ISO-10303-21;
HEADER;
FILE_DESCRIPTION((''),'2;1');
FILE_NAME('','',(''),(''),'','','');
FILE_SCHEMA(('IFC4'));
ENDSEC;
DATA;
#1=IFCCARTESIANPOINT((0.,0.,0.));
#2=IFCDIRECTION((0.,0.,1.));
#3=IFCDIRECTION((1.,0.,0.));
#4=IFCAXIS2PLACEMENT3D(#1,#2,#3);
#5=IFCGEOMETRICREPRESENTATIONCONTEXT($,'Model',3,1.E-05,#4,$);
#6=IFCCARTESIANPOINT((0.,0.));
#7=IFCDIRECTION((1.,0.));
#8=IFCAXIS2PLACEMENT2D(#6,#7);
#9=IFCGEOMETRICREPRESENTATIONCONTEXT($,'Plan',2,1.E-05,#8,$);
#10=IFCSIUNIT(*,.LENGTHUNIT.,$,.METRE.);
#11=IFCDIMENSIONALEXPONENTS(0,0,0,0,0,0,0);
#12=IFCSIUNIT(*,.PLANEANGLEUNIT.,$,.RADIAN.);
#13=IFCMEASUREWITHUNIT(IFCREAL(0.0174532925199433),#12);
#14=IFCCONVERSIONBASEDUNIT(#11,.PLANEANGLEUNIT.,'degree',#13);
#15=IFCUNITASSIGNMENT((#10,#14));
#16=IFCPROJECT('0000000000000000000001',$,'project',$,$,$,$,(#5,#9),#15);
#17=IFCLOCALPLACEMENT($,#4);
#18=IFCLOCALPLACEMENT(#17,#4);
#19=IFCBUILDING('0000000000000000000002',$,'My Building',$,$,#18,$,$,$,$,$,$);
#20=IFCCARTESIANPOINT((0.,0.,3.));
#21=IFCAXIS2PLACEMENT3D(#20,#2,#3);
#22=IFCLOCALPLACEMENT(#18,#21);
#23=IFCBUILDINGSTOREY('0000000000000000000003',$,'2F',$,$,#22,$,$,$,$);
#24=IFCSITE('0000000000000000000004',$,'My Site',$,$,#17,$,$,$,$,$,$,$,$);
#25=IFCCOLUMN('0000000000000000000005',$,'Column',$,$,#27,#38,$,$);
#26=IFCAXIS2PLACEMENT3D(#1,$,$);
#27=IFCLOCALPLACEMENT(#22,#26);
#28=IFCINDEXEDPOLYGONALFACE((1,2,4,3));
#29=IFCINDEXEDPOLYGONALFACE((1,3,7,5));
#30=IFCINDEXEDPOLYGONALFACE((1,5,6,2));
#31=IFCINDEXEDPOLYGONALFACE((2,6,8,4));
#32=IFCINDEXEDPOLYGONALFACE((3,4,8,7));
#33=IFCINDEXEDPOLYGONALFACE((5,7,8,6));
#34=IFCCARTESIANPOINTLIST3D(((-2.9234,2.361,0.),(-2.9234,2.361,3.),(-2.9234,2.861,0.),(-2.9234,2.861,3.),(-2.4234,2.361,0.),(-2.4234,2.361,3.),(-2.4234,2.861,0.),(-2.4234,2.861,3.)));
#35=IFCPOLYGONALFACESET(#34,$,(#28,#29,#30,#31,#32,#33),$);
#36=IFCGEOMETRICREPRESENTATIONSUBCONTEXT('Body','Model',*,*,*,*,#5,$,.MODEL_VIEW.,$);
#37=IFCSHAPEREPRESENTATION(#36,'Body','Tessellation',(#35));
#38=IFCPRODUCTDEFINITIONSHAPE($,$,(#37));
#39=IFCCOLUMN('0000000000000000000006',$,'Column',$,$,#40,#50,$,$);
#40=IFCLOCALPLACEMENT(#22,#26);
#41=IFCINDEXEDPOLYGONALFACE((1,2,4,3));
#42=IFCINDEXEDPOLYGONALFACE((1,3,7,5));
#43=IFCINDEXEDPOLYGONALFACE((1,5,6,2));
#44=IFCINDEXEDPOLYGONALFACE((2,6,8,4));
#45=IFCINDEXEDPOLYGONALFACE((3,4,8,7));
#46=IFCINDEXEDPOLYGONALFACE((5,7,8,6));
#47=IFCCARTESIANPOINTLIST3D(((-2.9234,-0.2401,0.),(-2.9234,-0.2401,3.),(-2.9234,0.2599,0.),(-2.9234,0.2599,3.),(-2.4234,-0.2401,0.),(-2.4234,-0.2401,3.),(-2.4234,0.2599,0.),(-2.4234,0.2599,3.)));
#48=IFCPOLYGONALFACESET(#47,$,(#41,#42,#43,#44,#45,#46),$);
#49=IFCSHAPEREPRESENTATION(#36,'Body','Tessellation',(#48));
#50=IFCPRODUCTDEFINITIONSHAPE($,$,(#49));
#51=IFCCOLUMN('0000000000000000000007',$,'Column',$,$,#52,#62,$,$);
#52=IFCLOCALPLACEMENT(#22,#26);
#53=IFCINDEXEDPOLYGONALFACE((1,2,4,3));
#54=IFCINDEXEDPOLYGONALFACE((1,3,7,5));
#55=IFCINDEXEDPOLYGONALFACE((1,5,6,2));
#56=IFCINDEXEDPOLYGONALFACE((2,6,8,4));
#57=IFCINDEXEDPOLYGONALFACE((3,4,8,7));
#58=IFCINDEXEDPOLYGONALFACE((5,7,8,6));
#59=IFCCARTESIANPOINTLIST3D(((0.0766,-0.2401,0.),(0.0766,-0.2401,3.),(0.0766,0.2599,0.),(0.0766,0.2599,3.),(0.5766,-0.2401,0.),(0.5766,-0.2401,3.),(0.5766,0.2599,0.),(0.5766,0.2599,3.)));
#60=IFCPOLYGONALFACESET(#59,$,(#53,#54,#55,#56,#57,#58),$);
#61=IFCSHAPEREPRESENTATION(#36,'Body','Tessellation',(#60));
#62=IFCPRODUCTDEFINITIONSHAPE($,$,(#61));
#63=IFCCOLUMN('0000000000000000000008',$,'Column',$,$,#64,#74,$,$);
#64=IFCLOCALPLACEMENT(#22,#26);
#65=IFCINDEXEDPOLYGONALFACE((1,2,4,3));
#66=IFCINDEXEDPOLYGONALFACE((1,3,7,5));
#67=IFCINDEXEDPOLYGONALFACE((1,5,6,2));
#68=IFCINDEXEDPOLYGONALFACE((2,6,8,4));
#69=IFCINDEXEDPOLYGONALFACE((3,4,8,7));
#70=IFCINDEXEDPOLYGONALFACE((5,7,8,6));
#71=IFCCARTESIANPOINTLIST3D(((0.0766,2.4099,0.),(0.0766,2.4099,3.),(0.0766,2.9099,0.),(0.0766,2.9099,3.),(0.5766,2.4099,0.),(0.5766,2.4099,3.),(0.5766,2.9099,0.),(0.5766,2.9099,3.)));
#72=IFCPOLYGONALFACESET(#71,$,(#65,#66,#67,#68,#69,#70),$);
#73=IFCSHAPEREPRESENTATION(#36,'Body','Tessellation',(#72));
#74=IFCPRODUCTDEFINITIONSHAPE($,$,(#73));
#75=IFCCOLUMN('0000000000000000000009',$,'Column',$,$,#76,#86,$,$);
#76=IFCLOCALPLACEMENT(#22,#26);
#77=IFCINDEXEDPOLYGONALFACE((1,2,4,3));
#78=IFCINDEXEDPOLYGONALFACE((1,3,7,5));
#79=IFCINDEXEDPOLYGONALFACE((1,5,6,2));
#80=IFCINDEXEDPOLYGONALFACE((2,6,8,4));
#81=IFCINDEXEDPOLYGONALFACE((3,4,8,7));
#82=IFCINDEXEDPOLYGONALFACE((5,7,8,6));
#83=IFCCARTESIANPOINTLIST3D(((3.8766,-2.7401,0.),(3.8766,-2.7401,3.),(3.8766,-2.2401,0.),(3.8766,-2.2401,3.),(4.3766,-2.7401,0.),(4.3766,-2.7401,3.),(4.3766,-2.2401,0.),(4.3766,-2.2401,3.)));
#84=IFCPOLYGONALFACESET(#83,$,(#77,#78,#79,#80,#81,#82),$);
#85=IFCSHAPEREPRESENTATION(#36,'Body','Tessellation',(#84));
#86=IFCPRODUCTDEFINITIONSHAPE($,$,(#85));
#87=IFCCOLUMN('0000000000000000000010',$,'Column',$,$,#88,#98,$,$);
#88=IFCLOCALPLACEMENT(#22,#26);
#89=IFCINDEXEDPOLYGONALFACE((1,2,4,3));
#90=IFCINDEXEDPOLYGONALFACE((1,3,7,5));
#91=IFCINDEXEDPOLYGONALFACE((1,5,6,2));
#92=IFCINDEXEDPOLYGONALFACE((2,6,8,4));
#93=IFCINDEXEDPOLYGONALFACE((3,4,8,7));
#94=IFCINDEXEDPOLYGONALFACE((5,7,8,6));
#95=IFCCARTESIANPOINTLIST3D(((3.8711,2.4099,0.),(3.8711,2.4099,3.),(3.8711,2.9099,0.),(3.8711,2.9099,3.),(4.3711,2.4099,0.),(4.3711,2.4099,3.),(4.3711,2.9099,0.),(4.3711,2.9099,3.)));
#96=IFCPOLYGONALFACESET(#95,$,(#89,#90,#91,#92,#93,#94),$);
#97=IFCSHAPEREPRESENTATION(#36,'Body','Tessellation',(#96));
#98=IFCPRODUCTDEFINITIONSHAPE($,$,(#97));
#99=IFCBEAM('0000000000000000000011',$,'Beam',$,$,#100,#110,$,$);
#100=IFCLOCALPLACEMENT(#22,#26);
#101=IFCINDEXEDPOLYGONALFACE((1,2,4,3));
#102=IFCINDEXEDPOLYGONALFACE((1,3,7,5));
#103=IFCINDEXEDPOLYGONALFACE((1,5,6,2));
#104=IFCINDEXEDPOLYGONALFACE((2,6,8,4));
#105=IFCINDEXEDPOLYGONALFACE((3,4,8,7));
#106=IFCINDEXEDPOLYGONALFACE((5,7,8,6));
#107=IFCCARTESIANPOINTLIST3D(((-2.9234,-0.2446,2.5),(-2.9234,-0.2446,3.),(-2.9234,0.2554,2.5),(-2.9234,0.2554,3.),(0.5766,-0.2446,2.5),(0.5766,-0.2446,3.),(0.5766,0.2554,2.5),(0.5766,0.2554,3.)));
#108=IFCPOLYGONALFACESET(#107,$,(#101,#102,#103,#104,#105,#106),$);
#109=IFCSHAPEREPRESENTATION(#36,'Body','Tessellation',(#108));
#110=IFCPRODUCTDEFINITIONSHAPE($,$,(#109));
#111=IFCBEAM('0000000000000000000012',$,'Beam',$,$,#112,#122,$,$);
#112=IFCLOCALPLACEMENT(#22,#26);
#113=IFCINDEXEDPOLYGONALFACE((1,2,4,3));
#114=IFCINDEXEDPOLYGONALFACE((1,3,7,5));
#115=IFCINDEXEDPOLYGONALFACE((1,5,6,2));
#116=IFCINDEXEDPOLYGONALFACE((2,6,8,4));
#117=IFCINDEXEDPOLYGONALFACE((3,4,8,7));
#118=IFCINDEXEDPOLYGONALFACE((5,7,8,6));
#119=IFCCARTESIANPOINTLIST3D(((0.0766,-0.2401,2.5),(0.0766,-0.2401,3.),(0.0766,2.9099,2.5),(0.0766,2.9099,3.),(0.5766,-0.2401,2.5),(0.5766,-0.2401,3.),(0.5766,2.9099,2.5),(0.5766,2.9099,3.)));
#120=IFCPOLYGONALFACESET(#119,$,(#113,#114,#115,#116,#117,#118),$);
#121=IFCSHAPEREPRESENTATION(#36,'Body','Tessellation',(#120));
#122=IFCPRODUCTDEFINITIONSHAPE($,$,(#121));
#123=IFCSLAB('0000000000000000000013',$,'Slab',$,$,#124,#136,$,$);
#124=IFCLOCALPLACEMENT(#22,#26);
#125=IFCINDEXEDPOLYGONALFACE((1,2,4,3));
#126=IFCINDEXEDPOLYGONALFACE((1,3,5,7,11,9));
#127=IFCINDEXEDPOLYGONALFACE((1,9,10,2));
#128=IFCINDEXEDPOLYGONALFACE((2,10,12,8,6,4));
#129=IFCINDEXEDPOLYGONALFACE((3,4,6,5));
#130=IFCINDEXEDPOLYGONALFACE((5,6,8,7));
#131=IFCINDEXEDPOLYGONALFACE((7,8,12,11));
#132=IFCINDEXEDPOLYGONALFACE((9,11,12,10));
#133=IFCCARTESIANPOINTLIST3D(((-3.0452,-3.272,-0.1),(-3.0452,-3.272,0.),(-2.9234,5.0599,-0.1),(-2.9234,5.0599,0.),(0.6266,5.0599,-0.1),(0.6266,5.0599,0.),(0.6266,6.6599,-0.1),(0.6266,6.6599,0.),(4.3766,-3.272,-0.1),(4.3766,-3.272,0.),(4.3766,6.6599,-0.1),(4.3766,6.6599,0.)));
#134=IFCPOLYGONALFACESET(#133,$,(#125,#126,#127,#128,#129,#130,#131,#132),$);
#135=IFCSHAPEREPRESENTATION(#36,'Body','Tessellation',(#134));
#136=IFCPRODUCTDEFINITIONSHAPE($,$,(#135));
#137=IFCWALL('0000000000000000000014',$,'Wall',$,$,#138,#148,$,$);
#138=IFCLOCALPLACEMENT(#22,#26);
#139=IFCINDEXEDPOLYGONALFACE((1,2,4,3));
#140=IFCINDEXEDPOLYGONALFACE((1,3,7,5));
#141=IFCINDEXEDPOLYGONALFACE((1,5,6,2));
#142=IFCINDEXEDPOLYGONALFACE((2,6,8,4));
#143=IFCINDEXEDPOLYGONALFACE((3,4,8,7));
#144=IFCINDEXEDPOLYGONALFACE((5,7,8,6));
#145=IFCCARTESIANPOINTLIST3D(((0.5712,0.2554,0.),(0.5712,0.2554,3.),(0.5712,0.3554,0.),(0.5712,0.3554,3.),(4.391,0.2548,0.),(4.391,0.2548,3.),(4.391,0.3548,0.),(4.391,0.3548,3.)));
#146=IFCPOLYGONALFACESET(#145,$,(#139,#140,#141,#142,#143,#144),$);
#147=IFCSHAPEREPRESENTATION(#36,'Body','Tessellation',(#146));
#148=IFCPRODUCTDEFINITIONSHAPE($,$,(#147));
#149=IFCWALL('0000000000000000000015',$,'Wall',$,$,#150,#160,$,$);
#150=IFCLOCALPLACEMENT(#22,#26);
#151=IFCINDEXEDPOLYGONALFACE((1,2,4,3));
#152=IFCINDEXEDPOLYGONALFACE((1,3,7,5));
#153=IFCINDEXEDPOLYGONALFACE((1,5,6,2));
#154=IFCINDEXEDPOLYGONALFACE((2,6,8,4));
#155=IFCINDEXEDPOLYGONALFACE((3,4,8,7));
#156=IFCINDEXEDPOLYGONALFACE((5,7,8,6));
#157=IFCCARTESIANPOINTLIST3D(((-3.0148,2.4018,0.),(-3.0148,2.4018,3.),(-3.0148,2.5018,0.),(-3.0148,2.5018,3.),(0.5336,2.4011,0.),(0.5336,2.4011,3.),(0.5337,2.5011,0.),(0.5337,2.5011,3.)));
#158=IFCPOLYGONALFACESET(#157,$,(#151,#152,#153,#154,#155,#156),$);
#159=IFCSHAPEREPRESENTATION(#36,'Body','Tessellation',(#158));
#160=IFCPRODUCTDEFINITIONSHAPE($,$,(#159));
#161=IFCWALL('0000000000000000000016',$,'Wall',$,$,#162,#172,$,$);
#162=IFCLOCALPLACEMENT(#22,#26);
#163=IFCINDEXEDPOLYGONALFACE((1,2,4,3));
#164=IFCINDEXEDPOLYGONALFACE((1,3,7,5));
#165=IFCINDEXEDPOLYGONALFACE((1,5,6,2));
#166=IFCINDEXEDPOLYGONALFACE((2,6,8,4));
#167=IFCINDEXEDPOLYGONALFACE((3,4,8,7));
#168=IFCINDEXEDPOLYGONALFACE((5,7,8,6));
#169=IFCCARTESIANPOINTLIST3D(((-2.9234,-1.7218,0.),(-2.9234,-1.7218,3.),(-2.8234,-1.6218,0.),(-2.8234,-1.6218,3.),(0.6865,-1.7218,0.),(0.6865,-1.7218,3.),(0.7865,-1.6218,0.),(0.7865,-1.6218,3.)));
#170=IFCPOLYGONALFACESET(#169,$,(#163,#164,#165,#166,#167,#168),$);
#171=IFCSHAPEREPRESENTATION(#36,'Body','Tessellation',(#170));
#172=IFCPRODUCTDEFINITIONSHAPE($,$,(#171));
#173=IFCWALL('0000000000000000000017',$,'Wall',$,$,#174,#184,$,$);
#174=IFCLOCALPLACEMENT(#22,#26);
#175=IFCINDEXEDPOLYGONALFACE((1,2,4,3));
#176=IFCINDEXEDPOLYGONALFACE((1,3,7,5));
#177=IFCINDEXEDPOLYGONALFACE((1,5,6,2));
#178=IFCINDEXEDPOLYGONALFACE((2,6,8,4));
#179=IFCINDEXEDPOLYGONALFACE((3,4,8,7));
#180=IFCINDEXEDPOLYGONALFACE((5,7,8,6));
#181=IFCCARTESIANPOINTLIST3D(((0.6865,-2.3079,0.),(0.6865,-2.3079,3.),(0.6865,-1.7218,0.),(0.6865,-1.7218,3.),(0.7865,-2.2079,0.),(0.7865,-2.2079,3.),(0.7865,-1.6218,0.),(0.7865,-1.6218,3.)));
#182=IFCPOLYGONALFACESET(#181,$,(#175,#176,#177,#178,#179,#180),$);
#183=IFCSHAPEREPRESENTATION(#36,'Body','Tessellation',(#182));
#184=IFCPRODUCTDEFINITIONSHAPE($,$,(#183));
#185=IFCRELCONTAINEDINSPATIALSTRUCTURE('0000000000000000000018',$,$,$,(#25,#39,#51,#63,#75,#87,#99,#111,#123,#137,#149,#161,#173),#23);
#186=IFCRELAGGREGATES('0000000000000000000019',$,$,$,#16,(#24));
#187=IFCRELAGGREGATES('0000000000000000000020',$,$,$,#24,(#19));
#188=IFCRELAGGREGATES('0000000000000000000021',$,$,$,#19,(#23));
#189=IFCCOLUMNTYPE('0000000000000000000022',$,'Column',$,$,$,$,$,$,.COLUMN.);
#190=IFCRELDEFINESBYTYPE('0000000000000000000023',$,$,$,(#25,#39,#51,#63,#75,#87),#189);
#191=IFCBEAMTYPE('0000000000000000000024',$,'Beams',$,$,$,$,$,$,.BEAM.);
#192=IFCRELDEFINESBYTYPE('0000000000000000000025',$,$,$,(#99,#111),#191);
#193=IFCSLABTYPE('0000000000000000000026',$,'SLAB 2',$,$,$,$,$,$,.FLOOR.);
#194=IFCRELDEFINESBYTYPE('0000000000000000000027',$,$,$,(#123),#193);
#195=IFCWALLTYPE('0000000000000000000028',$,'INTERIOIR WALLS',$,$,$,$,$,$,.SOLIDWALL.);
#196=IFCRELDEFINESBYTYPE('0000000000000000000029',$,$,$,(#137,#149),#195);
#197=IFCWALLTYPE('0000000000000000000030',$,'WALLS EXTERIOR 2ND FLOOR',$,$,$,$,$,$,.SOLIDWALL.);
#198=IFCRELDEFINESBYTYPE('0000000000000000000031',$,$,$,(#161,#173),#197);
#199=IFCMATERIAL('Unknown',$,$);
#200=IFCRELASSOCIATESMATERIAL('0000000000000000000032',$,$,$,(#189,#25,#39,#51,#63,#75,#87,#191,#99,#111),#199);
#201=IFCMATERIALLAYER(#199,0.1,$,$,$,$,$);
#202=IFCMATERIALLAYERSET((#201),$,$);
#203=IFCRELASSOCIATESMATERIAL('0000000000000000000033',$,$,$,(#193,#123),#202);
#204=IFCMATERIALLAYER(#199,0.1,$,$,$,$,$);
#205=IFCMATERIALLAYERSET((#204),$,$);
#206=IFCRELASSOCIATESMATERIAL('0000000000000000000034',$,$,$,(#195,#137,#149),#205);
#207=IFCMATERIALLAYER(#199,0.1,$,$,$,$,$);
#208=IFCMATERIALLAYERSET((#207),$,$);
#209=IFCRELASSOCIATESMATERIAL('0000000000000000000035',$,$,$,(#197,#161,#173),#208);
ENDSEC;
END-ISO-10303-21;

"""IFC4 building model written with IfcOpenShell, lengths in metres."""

from ifc_helpers import new_model, entity, si_unit, converted_unit, frame, origin_with_axes, origin_2d_with_axis, place, context, subcontext, project, spatial, line, indexed_curve, rectangle, outline, extrude, material, layer, layer_set, layer_usage, material_profile, profile_set, profile_usage, type_object, element, save


model = new_model("IFC4")

# Units and contexts
model_context = context("Model", 3, precision=1e-05, world=origin_with_axes())
plan_context = context("Plan", 2, precision=1e-05, world=origin_2d_with_axis())
body_context_1 = subcontext(model_context, "Body", "Model", "MODEL_VIEW")
ifc_project = project(units=[si_unit("LENGTHUNIT", "METRE"), converted_unit("PLANEANGLEUNIT", "degree", entity("IfcReal", 0.0174532925199433), si_unit("PLANEANGLEUNIT", "RADIAN"), dimensions=[0, 0, 0, 0, 0, 0, 0])], contexts=[model_context, plan_context])

# Site, building, storey
site_placement = place(None, origin_with_axes())
site = spatial("IfcSite", under=ifc_project, at=site_placement, Name="My Site")
building_placement = place(site_placement, origin_with_axes())
building = spatial("IfcBuilding", under=site, at=building_placement, Name="My Building")
storey_placement = place(building_placement, frame((0.0, 0.0, 3.0), z_axis=(0.0, 0.0, 1.0), x_axis=(1.0, 0.0, 0.0)))
storey = spatial("IfcBuildingStorey", under=building, at=storey_placement, Name="2F")

# Columns
ifc_material = material(Name="Unknown")
ifc_material_profile_1 = material_profile(ifc_material, rectangle(XDim=0.5, YDim=0.5))
ifc_profile_set_1 = profile_set([ifc_material_profile_1])
ifc_profile_usage_1 = profile_usage(ifc_profile_set_1, cardinal=5)
column_type = type_object("IfcColumnType", Name="Column", PredefinedType="COLUMN", material=ifc_profile_set_1)
column_1_placement = place(storey_placement, frame((-2.6734, 2.611, 0.0), z_axis=(0.0, 0.0, 1.0), x_axis=(1.0, 0.0, 0.0)))
element("IfcColumn", 1, at=column_1_placement, inside=storey, type_object=column_type, material=ifc_profile_usage_1, Name="Column", context=body_context_1, shape_type="SweptSolid", body=[
    extrude(rectangle(XDim=0.5, YDim=0.5), origin_with_axes(), (0.0, 0.0, 1.0), 3.0),
])
ifc_profile_usage_2 = profile_usage(ifc_profile_set_1, cardinal=5)
column_2_placement = place(storey_placement, frame((-2.6734, 0.0099, 0.0), z_axis=(0.0, 0.0, 1.0), x_axis=(1.0, 0.0, 0.0)))
element("IfcColumn", 2, at=column_2_placement, inside=storey, type_object=column_type, material=ifc_profile_usage_2, Name="Column", context=body_context_1, shape_type="SweptSolid", body=[
    extrude(rectangle(XDim=0.5, YDim=0.5), origin_with_axes(), (0.0, 0.0, 1.0), 3.0),
])
ifc_profile_usage_3 = profile_usage(ifc_profile_set_1, cardinal=5)
column_3_placement = place(storey_placement, frame((0.3266, 0.0099, 0.0), z_axis=(0.0, 0.0, 1.0), x_axis=(1.0, 0.0, 0.0)))
element("IfcColumn", 3, at=column_3_placement, inside=storey, type_object=column_type, material=ifc_profile_usage_3, Name="Column", context=body_context_1, shape_type="SweptSolid", body=[
    extrude(rectangle(XDim=0.5, YDim=0.5), origin_with_axes(), (0.0, 0.0, 1.0), 3.0),
])
ifc_profile_usage_4 = profile_usage(ifc_profile_set_1, cardinal=5)
column_4_placement = place(storey_placement, frame((0.3266, 2.6599, 0.0), z_axis=(0.0, 0.0, 1.0), x_axis=(1.0, 0.0, 0.0)))
element("IfcColumn", 4, at=column_4_placement, inside=storey, type_object=column_type, material=ifc_profile_usage_4, Name="Column", context=body_context_1, shape_type="SweptSolid", body=[
    extrude(rectangle(XDim=0.5, YDim=0.5), origin_with_axes(), (0.0, 0.0, 1.0), 3.0),
])
ifc_profile_usage_5 = profile_usage(ifc_profile_set_1, cardinal=5)
column_5_placement = place(storey_placement, frame((4.1266, -2.4901, 0.0), z_axis=(0.0, 0.0, 1.0), x_axis=(1.0, 0.0, 0.0)))
element("IfcColumn", 5, at=column_5_placement, inside=storey, type_object=column_type, material=ifc_profile_usage_5, Name="Column", context=body_context_1, shape_type="SweptSolid", body=[
    extrude(rectangle(XDim=0.5, YDim=0.5), origin_with_axes(), (0.0, 0.0, 1.0), 3.0),
])
ifc_profile_usage_6 = profile_usage(ifc_profile_set_1, cardinal=5)
column_6_placement = place(storey_placement, frame((4.1211, 2.6599, 0.0), z_axis=(0.0, 0.0, 1.0), x_axis=(1.0, 0.0, 0.0)))
element("IfcColumn", 6, at=column_6_placement, inside=storey, type_object=column_type, material=ifc_profile_usage_6, Name="Column", context=body_context_1, shape_type="SweptSolid", body=[
    extrude(rectangle(XDim=0.5, YDim=0.5), origin_with_axes(), (0.0, 0.0, 1.0), 3.0),
])

# Beams
ifc_material_profile_2 = material_profile(ifc_material, rectangle(XDim=0.5, YDim=0.5))
ifc_profile_set_2 = profile_set([ifc_material_profile_2])
ifc_profile_usage_7 = profile_usage(ifc_profile_set_2, cardinal=7)
beam_type = type_object("IfcBeamType", Name="Beams", PredefinedType="BEAM", material=ifc_profile_set_2)
beam_1_placement = place(storey_placement, frame((-2.9234, 0.2554, 3.0), z_axis=(1.0, 0.0, 0.0), x_axis=(0.0, 1.0, 0.0)))
element("IfcBeam", 7, at=beam_1_placement, inside=storey, type_object=beam_type, material=ifc_profile_usage_7, Name="Beam", context=body_context_1, shape_type="SweptSolid", body=[
    extrude(rectangle(XDim=0.5, YDim=0.5), frame((-0.25, -0.25, 0.0), z_axis=(0.0, 0.0, 1.0), x_axis=(1.0, 0.0, 0.0)), (0.0, 0.0, 1.0), 3.5),
])
ifc_profile_usage_8 = profile_usage(ifc_profile_set_2, cardinal=7)
beam_2_placement = place(storey_placement, frame((0.0766, -0.2401, 3.0), z_axis=(0.0, 1.0, 0.0), x_axis=(-1.0, 0.0, 0.0)))
element("IfcBeam", 8, at=beam_2_placement, inside=storey, type_object=beam_type, material=ifc_profile_usage_8, Name="Beam", context=body_context_1, shape_type="SweptSolid", body=[
    extrude(rectangle(XDim=0.5, YDim=0.5), frame((-0.25, -0.25, 0.0), z_axis=(0.0, 0.0, 1.0), x_axis=(1.0, 0.0, 0.0)), (0.0, 0.0, 1.0), 3.15),
])

# Slab
ifc_layer_1 = layer(ifc_material, 0.1)
ifc_layer_set_1 = layer_set([ifc_layer_1])
ifc_layer_usage_1 = layer_usage(ifc_layer_set_1, "AXIS3", "POSITIVE", -0.1)
slab_type = type_object("IfcSlabType", Name="SLAB 2", PredefinedType="FLOOR", material=ifc_layer_set_1)
slab_placement = place(storey_placement, frame((4.3766, -3.272, 0.0), z_axis=(0.0, 0.0, 1.0), x_axis=(1.0, 0.0, 0.0)))
element("IfcSlab", 9, at=slab_placement, inside=storey, type_object=slab_type, material=ifc_layer_usage_1, Name="Slab", context=body_context_1, shape_type="SweptSolid", body=[
    extrude(outline(indexed_curve([(0.0, 0.0), (0.0, 9.9319), (-3.75, 9.9319), (-3.75, 8.3319), (-7.3, 8.3319), (-7.4218, 0.0), (0.0, 0.0)])), frame((0.0, 0.0, -0.1), z_axis=(0.0, 0.0, 1.0), x_axis=(1.0, 0.0, 0.0)), (0.0, 0.0, 1.0), 0.1),
])

# Walls
ifc_layer_2 = layer(ifc_material, 0.1)
ifc_layer_set_2 = layer_set([ifc_layer_2])
ifc_layer_usage_2 = layer_usage(ifc_layer_set_2, "AXIS2", "POSITIVE", 0.0)
wall_type_1 = type_object("IfcWallType", Name="INTERIOIR WALLS", PredefinedType="SOLIDWALL", material=ifc_layer_set_2)
wall_1_placement = place(storey_placement, frame((4.391, 0.3548, 0.0), z_axis=(0.0, 0.0, 1.0), x_axis=(-1.0, 0.000143, 0.0)))
element("IfcWall", 10, at=wall_1_placement, inside=storey, type_object=wall_type_1, material=ifc_layer_usage_2, Name="Wall", context=body_context_1, shape_type="SweptSolid", body=[
    extrude(outline(indexed_curve([(0.0, 0.0), (0.0, 0.1), (3.8198, 0.1), (3.8198, 0.0)], segments=[line(1, 2, 3, 4, 1)])), origin_with_axes(), (0.0, 0.0, 1.0), 3.0),
])
ifc_layer_usage_3 = layer_usage(ifc_layer_set_2, "AXIS2", "POSITIVE", 0.0)
wall_2_placement = place(storey_placement, frame((-3.0148, 2.4018, 0.0), z_axis=(0.0, 0.0, 1.0), x_axis=(1.0, -0.000214, 0.0)))
element("IfcWall", 11, at=wall_2_placement, inside=storey, type_object=wall_type_1, material=ifc_layer_usage_3, Name="Wall", context=body_context_1, shape_type="SweptSolid", body=[
    extrude(outline(indexed_curve([(0.0, 0.0), (0.0, 0.1), (3.5485, 0.1), (3.5485, 0.0)], segments=[line(1, 2, 3, 4, 1)])), origin_with_axes(), (0.0, 0.0, 1.0), 3.0),
])
ifc_layer_3 = layer(ifc_material, 0.1)
ifc_layer_set_3 = layer_set([ifc_layer_3])
ifc_layer_usage_4 = layer_usage(ifc_layer_set_3, "AXIS2", "POSITIVE", 0.0)
wall_type_2 = type_object("IfcWallType", Name="WALLS EXTERIOR 2ND FLOOR", PredefinedType="SOLIDWALL", material=ifc_layer_set_3)
wall_3_placement = place(storey_placement, frame((-2.9234, -1.7218, 0.0), z_axis=(0.0, 0.0, 1.0), x_axis=(1.0, 0.0, 0.0)))
element("IfcWall", 12, at=wall_3_placement, inside=storey, type_object=wall_type_2, material=ifc_layer_usage_4, Name="Wall", context=body_context_1, shape_type="SweptSolid", body=[
    extrude(outline(indexed_curve([(0.0, 0.0), (0.1, 0.1), (3.7099, 0.1), (3.6099, 0.0)], segments=[line(1, 2, 3, 4, 1)])), origin_with_axes(), (0.0, 0.0, 1.0), 3.0),
])
ifc_layer_usage_5 = layer_usage(ifc_layer_set_3, "AXIS2", "POSITIVE", 0.0)
wall_4_placement = place(storey_placement, frame((0.6865, -1.7218, 0.0), z_axis=(0.0, 0.0, 1.0), x_axis=(0.0, -1.0, 0.0)))
element("IfcWall", 13, at=wall_4_placement, inside=storey, type_object=wall_type_2, material=ifc_layer_usage_5, Name="Wall", context=body_context_1, shape_type="SweptSolid", body=[
    extrude(outline(indexed_curve([(0.0, 0.0), (-0.1, 0.1), (0.4861, 0.1), (0.5861, 0.0)], segments=[line(1, 2, 3, 4, 1)])), origin_with_axes(), (0.0, 0.0, 1.0), 3.0),
])

save(model, "model.ifc")
